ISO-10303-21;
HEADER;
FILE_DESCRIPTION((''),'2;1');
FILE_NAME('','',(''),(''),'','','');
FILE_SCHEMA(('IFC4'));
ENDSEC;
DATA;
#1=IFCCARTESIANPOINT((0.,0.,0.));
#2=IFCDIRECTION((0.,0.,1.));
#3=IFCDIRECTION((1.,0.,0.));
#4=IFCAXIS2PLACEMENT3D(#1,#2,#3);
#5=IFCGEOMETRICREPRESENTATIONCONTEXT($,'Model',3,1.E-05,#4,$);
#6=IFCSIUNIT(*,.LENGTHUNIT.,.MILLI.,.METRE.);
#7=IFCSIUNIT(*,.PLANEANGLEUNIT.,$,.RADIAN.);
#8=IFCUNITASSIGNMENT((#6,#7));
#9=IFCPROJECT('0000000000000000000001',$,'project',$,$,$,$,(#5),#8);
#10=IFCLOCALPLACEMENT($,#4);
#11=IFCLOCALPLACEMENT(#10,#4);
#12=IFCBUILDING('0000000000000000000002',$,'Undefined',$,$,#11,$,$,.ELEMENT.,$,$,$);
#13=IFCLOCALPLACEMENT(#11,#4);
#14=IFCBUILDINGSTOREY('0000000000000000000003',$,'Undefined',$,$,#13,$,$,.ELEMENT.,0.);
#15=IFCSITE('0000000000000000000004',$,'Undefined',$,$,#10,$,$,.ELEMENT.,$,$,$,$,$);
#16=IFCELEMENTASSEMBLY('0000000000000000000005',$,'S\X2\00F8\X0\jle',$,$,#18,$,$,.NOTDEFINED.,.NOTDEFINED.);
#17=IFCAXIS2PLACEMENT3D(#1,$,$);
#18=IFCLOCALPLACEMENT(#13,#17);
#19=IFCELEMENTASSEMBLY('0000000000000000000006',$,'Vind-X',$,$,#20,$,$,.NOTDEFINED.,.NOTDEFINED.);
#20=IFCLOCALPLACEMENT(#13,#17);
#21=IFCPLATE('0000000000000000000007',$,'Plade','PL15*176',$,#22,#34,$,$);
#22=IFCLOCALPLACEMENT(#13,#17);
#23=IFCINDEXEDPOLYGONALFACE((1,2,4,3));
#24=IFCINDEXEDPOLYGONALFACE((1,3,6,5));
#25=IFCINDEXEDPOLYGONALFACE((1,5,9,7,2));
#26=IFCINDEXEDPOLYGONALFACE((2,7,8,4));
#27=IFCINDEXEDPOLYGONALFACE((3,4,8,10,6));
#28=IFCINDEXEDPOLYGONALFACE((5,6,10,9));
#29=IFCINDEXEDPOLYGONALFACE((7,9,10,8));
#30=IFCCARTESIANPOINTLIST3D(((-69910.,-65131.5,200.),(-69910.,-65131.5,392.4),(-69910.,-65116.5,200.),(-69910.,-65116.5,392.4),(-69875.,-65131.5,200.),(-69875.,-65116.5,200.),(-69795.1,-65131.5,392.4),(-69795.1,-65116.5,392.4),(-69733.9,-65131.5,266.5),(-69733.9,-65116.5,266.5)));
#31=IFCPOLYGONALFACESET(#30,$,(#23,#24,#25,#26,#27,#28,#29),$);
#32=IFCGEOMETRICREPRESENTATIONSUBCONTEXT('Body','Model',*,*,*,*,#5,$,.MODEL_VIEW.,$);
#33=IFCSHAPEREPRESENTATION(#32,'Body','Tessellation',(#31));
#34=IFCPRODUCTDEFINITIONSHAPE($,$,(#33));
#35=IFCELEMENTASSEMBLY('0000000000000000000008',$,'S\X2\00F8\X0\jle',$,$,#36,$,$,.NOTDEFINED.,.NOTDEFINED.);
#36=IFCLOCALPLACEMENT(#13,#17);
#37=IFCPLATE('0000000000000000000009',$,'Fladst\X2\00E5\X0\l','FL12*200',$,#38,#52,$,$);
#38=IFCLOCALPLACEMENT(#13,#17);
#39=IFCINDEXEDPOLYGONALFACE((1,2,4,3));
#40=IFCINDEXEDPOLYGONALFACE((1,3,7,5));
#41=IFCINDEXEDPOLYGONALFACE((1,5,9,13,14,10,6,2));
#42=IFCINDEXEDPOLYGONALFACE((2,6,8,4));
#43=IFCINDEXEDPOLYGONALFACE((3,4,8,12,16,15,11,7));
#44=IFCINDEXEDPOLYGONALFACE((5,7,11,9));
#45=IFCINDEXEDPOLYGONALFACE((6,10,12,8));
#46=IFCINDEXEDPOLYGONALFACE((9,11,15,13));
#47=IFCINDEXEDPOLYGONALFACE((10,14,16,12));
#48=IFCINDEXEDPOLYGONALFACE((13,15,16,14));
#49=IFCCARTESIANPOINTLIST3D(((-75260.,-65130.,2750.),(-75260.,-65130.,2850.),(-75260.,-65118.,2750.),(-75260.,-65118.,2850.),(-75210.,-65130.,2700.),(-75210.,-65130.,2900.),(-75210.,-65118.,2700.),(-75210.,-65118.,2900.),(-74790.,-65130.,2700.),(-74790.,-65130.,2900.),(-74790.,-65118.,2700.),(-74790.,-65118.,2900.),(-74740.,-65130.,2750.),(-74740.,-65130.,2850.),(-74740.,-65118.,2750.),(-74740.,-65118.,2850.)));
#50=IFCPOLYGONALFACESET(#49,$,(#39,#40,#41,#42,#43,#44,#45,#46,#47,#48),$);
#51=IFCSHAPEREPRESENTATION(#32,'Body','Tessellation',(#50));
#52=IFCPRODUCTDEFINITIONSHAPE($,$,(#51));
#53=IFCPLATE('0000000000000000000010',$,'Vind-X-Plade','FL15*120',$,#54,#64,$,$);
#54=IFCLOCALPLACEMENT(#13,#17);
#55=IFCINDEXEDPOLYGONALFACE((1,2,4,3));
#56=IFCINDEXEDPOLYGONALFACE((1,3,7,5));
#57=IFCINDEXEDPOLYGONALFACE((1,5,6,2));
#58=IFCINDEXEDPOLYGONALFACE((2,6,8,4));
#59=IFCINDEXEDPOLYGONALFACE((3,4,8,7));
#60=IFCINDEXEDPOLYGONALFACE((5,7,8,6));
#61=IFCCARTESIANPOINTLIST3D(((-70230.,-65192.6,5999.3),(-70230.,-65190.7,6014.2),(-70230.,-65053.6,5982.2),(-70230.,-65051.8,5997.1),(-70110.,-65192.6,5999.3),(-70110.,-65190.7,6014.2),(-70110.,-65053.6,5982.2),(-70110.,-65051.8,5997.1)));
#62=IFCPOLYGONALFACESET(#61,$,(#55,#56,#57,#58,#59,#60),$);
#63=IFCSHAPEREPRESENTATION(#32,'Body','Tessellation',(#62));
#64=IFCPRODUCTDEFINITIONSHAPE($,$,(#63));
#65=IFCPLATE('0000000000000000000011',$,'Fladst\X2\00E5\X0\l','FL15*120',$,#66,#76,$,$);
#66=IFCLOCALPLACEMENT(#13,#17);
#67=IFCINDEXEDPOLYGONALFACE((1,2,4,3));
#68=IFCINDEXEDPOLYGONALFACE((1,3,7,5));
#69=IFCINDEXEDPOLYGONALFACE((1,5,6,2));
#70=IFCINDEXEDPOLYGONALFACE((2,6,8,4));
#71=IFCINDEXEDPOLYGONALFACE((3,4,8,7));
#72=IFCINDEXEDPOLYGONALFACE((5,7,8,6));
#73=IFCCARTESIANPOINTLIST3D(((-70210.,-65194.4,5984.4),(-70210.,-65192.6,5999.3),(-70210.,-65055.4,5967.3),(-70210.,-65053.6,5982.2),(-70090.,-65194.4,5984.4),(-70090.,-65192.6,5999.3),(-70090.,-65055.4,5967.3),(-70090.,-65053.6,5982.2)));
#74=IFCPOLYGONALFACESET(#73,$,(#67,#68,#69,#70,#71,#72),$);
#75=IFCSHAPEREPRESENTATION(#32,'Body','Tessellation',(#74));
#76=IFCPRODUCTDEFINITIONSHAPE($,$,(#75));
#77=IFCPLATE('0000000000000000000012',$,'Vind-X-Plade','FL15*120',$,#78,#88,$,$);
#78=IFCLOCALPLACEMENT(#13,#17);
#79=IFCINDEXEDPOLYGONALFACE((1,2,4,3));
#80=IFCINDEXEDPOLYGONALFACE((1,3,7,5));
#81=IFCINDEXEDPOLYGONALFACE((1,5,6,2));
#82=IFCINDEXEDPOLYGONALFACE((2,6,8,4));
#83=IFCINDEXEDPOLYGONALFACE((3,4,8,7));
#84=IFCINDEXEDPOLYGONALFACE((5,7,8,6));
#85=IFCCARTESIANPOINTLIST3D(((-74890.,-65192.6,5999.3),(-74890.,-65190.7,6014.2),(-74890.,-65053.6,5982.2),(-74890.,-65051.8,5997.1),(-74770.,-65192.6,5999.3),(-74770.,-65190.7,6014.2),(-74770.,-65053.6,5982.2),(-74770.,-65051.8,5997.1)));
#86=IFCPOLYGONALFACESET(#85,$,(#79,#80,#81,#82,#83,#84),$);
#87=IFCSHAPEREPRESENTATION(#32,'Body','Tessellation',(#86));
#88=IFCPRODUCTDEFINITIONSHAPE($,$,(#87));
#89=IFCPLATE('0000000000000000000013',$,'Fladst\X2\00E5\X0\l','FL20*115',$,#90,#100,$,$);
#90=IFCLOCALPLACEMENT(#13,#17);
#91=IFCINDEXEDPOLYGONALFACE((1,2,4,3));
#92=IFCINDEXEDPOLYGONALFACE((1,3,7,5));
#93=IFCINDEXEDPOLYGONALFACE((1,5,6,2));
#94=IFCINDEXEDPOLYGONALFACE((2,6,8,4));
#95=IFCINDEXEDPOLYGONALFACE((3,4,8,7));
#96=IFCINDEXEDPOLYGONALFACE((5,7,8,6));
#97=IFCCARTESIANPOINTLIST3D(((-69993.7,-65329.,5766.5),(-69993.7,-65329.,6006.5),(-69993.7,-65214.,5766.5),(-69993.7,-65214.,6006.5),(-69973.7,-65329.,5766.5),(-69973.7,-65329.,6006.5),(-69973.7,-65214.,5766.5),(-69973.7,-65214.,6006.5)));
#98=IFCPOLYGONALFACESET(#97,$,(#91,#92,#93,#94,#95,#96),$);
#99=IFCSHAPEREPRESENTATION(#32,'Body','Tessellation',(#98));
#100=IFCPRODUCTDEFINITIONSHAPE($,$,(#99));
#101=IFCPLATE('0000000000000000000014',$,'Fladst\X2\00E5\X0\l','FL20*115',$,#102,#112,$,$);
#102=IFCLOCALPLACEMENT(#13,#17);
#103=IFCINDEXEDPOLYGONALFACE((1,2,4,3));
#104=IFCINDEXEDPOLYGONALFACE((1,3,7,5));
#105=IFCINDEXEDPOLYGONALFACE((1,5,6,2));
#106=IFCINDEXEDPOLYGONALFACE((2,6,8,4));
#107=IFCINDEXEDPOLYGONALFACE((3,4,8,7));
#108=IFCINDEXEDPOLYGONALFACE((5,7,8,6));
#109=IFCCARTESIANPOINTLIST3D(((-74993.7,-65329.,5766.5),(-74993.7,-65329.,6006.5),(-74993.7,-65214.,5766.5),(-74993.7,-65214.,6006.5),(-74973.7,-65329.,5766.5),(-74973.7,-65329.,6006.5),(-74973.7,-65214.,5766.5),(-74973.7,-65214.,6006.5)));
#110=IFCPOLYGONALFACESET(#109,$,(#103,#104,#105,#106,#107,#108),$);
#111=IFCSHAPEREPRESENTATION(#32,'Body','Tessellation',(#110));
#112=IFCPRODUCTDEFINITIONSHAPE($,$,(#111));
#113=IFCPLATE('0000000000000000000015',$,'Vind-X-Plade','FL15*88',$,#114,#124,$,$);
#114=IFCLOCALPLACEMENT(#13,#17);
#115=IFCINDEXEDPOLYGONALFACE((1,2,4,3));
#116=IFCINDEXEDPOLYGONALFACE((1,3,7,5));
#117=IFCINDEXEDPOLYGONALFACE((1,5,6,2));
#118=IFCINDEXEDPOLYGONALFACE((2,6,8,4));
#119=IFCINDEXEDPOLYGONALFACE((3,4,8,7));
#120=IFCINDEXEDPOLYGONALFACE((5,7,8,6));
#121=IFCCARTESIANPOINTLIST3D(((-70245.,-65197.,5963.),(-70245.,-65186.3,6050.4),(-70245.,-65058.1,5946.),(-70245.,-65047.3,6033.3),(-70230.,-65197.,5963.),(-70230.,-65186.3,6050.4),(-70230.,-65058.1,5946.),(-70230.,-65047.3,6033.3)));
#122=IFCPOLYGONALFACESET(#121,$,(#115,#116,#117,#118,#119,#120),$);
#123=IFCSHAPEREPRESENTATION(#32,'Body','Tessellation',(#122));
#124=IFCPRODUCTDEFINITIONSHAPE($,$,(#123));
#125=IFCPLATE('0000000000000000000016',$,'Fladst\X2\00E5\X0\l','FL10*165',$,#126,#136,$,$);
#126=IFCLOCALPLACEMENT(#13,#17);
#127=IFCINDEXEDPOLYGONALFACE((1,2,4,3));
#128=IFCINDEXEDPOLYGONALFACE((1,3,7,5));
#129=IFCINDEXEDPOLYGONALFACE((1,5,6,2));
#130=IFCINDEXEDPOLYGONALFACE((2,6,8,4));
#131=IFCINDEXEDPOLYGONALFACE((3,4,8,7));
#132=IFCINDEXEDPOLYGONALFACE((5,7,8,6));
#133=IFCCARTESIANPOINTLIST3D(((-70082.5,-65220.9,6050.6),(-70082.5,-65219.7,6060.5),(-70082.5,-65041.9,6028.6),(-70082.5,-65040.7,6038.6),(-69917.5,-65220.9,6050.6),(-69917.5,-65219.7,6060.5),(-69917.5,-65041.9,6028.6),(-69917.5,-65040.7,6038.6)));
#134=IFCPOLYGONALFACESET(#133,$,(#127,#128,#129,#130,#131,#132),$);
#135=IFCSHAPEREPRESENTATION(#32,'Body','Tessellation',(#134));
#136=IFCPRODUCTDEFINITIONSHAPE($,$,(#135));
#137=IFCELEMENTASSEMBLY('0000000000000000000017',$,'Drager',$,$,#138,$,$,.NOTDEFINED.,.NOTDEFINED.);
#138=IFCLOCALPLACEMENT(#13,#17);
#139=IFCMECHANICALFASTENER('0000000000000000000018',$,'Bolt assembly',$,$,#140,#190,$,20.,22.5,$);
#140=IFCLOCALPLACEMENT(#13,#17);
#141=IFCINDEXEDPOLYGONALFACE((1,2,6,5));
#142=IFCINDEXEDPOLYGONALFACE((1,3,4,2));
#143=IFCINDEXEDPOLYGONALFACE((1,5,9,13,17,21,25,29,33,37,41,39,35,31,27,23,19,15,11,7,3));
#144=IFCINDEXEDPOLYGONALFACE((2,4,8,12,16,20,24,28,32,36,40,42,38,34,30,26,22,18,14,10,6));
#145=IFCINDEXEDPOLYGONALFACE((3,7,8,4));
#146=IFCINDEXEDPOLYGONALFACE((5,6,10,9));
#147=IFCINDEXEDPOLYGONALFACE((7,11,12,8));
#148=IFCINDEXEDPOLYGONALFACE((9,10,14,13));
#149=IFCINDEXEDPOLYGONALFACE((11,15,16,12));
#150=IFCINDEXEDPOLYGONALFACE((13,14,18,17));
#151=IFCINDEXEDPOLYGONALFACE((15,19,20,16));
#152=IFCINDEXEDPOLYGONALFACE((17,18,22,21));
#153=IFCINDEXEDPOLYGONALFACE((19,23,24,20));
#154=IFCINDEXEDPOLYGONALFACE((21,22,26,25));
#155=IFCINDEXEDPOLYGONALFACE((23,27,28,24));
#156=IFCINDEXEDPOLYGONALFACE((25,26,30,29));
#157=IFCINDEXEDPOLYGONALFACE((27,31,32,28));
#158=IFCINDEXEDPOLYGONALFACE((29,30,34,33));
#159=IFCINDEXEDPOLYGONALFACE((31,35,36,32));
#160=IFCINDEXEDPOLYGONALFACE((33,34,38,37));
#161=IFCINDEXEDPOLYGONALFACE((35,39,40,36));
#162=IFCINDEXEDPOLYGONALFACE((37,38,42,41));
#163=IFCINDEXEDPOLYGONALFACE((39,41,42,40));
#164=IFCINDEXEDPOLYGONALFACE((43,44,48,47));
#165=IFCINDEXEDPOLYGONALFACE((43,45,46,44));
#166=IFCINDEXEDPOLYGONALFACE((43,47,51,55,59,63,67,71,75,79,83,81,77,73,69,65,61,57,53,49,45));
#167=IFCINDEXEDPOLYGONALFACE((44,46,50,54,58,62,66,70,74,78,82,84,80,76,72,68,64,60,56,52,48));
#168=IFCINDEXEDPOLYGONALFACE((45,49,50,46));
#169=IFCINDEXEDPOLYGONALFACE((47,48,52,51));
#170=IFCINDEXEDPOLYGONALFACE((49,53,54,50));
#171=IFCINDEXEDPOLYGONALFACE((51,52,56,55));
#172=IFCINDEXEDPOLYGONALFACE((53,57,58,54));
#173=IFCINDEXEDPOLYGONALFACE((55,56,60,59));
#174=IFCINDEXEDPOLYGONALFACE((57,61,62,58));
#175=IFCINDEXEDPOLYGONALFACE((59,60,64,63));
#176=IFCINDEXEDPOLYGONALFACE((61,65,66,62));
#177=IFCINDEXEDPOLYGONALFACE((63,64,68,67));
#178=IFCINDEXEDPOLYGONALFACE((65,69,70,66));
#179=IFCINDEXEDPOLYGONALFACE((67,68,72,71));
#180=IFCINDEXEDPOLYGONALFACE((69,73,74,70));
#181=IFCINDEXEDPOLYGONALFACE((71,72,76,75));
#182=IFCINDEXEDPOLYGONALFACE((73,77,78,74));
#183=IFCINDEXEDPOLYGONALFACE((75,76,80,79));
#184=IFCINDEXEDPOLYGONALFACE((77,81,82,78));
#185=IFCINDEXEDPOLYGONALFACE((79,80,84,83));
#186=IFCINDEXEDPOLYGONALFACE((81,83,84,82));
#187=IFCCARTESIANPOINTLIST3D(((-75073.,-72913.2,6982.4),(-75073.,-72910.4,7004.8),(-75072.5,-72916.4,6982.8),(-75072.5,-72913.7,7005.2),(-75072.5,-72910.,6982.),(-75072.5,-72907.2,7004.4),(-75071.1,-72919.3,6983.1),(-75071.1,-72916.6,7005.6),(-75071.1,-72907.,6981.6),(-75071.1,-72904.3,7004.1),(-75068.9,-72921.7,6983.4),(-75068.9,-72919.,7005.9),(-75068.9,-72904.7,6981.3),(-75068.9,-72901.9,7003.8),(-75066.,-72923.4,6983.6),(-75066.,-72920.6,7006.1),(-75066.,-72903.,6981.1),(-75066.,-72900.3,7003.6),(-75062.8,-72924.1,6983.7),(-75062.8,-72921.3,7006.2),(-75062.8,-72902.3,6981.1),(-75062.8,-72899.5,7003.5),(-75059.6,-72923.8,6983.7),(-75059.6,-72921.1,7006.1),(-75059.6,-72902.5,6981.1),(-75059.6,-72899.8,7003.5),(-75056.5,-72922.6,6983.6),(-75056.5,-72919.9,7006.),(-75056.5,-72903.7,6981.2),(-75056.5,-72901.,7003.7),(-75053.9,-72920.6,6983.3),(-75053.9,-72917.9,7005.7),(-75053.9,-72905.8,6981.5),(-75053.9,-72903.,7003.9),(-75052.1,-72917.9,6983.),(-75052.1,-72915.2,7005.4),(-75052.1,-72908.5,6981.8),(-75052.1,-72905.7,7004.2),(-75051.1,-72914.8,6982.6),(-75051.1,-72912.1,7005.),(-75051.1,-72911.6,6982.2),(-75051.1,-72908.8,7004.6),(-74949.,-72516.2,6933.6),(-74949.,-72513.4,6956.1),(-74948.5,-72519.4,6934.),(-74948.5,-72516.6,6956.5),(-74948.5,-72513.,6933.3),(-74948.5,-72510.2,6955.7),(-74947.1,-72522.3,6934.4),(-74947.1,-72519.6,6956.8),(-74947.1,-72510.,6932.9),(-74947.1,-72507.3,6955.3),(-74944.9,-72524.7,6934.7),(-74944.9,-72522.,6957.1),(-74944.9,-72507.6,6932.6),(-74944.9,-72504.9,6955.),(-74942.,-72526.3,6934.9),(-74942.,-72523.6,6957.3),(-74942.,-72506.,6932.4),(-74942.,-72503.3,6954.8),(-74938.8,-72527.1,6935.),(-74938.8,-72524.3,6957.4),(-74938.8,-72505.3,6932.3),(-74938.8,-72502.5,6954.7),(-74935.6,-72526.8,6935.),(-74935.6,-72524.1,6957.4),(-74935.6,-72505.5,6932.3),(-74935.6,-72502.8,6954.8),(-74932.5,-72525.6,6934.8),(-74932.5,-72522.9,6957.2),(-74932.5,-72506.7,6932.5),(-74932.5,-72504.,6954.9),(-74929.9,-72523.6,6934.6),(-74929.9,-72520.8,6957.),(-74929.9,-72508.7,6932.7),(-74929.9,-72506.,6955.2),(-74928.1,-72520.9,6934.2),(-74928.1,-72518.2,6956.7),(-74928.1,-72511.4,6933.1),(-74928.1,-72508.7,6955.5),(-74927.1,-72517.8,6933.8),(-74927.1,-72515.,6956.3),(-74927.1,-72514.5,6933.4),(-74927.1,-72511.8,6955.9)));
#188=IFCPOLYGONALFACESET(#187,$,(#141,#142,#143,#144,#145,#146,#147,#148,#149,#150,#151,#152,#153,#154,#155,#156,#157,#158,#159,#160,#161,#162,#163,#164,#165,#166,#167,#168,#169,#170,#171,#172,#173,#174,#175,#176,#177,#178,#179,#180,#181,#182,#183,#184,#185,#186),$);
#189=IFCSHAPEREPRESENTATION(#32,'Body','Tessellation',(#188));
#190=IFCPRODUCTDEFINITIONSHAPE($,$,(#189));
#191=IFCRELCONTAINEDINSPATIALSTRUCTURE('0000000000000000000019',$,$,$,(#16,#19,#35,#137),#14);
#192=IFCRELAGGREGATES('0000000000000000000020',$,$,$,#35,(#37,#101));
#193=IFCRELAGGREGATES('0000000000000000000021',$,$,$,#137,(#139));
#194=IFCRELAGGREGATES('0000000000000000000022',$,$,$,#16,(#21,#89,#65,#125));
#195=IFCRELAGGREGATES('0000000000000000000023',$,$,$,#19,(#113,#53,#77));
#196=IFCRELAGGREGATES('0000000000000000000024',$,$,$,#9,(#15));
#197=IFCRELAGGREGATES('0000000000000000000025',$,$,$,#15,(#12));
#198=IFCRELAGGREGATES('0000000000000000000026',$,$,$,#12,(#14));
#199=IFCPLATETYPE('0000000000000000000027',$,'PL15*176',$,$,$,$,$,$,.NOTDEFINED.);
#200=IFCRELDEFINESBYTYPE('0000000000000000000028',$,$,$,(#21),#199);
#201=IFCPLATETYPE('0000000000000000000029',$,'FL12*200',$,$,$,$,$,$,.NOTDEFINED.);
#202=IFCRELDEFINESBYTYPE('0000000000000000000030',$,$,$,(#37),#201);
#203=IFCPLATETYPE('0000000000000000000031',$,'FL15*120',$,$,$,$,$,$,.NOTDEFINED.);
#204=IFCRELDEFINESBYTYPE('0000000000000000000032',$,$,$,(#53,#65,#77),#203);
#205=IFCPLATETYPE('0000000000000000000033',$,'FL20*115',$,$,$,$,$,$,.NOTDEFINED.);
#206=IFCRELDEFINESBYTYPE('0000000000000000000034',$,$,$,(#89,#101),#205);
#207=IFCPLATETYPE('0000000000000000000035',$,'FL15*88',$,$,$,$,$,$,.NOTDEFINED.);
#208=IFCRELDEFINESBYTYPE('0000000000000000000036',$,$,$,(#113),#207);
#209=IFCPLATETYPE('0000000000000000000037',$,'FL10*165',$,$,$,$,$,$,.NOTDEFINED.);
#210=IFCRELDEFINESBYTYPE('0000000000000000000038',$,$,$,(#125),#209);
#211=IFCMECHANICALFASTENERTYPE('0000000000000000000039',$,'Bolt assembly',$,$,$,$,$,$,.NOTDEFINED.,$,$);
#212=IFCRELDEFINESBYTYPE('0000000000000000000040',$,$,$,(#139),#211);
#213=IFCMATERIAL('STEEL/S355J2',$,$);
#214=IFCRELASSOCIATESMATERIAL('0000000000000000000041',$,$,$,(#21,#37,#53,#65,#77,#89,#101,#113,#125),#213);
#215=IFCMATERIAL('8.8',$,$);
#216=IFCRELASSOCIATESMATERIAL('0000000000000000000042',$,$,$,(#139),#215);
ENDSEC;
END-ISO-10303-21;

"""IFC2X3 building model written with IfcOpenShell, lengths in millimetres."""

from ifc_helpers import new_model, si_unit, frame, origin_with_axes, origin_2d_with_axis, place, context, subcontext, project, spatial, polyline, circle, outline, extrude, source, transform, mapped, material, type_object, element, aggregate, save


model = new_model("IFC2X3")

# Units and contexts
model_context = context("Model", 3, precision=1e-05, world=origin_with_axes())
body_context = subcontext(model_context, "Body", "Model", "MODEL_VIEW")
ifc_project = project(units=[si_unit("LENGTHUNIT", "METRE", prefix="MILLI"), si_unit("PLANEANGLEUNIT", "RADIAN")], contexts=[model_context])

# Site, building, storey
site_placement = place(None, origin_with_axes())
site = spatial("IfcSite", under=ifc_project, at=site_placement, Name="Undefined", CompositionType="ELEMENT")
building_placement = place(site_placement, origin_with_axes())
building = spatial("IfcBuilding", under=site, at=building_placement, Name="Undefined", CompositionType="ELEMENT")
storey_placement = place(building_placement, origin_with_axes())
storey = spatial("IfcBuildingStorey", under=building, at=storey_placement, Name="Undefined", CompositionType="ELEMENT", Elevation=0.0)

# Element assembly
assembly_1_placement = place(storey_placement, origin_with_axes())
assembly_1 = element("IfcElementAssembly", 1, at=assembly_1_placement, inside=storey, Name="Søjle", AssemblyPlace="NOTDEFINED", PredefinedType="NOTDEFINED")

# Element assembly
assembly_2_placement = place(storey_placement, origin_with_axes())
assembly_2 = element("IfcElementAssembly", 2, at=assembly_2_placement, inside=storey, Name="Vind-X", AssemblyPlace="NOTDEFINED", PredefinedType="NOTDEFINED")

# Shared definitions
ifc_material_1 = material(Name="STEEL/S355J2")

# Plate
plate_type_1 = type_object("IfcPlateType", Name="PL15*176", PredefinedType="NOTDEFINED")
plate_1_placement = place(assembly_1_placement, frame((-69910.0, -65124.0, 200.0), z_axis=(0.0, 1.0, 0.0), x_axis=(0.0, 0.0, 1.0)))
plate_1 = element("IfcPlate", 3, at=plate_1_placement, type_object=plate_type_1, material=ifc_material_1, Name="Plade", Description="PL15*176", context=body_context, shape_type="SweptSolid", body=[
    extrude(outline(polyline([(0.0, 0.0), (192.4, 0.0), (192.4, 114.9), (66.5, 176.1), (0.0, 35.0), (0.0, 0.0)])), frame((0.0, 0.0, -7.5), z_axis=(0.0, 0.0, 1.0), x_axis=(1.0, 0.0, 0.0)), (0.0, 0.0, 1.0), 15.0),
])

# Element assembly, plate
assembly_3_placement = place(storey_placement, origin_with_axes())
assembly_3 = element("IfcElementAssembly", 4, at=assembly_3_placement, inside=storey, Name="Søjle", AssemblyPlace="NOTDEFINED", PredefinedType="NOTDEFINED")
plate_type_2 = type_object("IfcPlateType", Name="FL12*200", PredefinedType="NOTDEFINED")
plate_2_placement = place(assembly_3_placement, frame((-74740.0, -65124.0, 2900.0), z_axis=(0.0, 1.0, 0.0), x_axis=(0.0, 0.0, -1.0)))
plate_2 = element("IfcPlate", 5, at=plate_2_placement, type_object=plate_type_2, material=ifc_material_1, Name="Fladstål", Description="FL12*200", context=body_context, shape_type="SweptSolid", body=[
    extrude(outline(polyline([(0.0, 50.0), (50.0, 0.0), (150.0, 0.0), (200.0, 50.0), (200.0, 470.0), (150.0, 520.0), (50.0, 520.0), (0.0, 470.0), (0.0, 50.0)])), frame((0.0, 0.0, -6.0), z_axis=(0.0, 0.0, 1.0), x_axis=(1.0, 0.0, 0.0)), (0.0, 0.0, 1.0), 12.0),
])

# Plates
plate_type_3 = type_object("IfcPlateType", Name="FL15*120", PredefinedType="NOTDEFINED")
plate_3_placement = place(assembly_2_placement, frame((-70110.0, -65122.2, 5998.2), z_axis=(0.0, -0.121869, -0.992546), x_axis=(-1.0, 0.0, 0.0)))
plate_3 = element("IfcPlate", 6, at=plate_3_placement, type_object=plate_type_3, material=ifc_material_1, Name="Vind-X-Plade", Description="FL15*120", context=body_context, shape_type="SweptSolid", body=[
    extrude(outline(polyline([(0.0, -70.0), (0.0, 70.0), (120.0, 70.0), (120.0, -70.0), (0.0, -70.0)])), frame((0.0, 0.0, -7.5), z_axis=(0.0, 0.0, 1.0), x_axis=(1.0, 0.0, 0.0)), (0.0, 0.0, 1.0), 15.0),
])
plate_4_placement = place(assembly_1_placement, frame((-70090.0, -65193.5, 5991.8), z_axis=(0.0, 0.121869, 0.992546), x_axis=(0.0, 0.992546, -0.121869)))
plate_4 = element("IfcPlate", 7, at=plate_4_placement, type_object=plate_type_3, material=ifc_material_1, Name="Fladstål", Description="FL15*120", context=body_context, shape_type="SweptSolid", body=[
    extrude(outline(polyline([(0.0, 0.0), (140.0, 0.0), (140.0, 120.0), (0.0, 120.0), (0.0, 0.0)])), frame((0.0, 0.0, -7.5), z_axis=(0.0, 0.0, 1.0), x_axis=(1.0, 0.0, 0.0)), (0.0, 0.0, 1.0), 15.0),
])
plate_5_placement = place(assembly_2_placement, frame((-74890.0, -65122.2, 5998.2), z_axis=(0.0, -0.121869, -0.992546), x_axis=(1.0, 0.0, 0.0)))
plate_5 = element("IfcPlate", 8, at=plate_5_placement, type_object=plate_type_3, material=ifc_material_1, Name="Vind-X-Plade", Description="FL15*120", context=body_context, shape_type="SweptSolid", body=[
    extrude(outline(polyline([(0.0, -70.0), (0.0, 70.0), (120.0, 70.0), (120.0, -70.0), (0.0, -70.0)])), frame((0.0, 0.0, -7.5), z_axis=(0.0, 0.0, 1.0), x_axis=(1.0, 0.0, 0.0)), (0.0, 0.0, 1.0), 15.0),
])
plate_type_4 = type_object("IfcPlateType", Name="FL20*115", PredefinedType="NOTDEFINED")
plate_6_placement = place(assembly_1_placement, frame((-69983.7, -65214.0, 6006.5), z_axis=(-1.0, 0.0, 0.0), x_axis=(0.0, 0.0, -1.0)))
plate_6 = element("IfcPlate", 9, at=plate_6_placement, type_object=plate_type_4, material=ifc_material_1, Name="Fladstål", Description="FL20*115", context=body_context, shape_type="SweptSolid", body=[
    extrude(outline(polyline([(0.0, 0.0), (240.0, 0.0), (240.0, 115.0), (0.0, 115.0), (0.0, 0.0)])), frame((0.0, 0.0, -10.0), z_axis=(0.0, 0.0, 1.0), x_axis=(1.0, 0.0, 0.0)), (0.0, 0.0, 1.0), 20.0),
])
plate_7_placement = place(assembly_3_placement, frame((-74983.7, -65214.0, 6006.5), z_axis=(-1.0, 0.0, 0.0), x_axis=(0.0, 0.0, -1.0)))
plate_7 = element("IfcPlate", 10, at=plate_7_placement, type_object=plate_type_4, material=ifc_material_1, Name="Fladstål", Description="FL20*115", context=body_context, shape_type="SweptSolid", body=[
    extrude(outline(polyline([(0.0, 0.0), (240.0, 0.0), (240.0, 115.0), (0.0, 115.0), (0.0, 0.0)])), frame((0.0, 0.0, -10.0), z_axis=(0.0, 0.0, 1.0), x_axis=(1.0, 0.0, 0.0)), (0.0, 0.0, 1.0), 20.0),
])
aggregate(assembly_3, [plate_2, plate_7])
plate_type_5 = type_object("IfcPlateType", Name="FL15*88", PredefinedType="NOTDEFINED")
plate_8_placement = place(assembly_2_placement, frame((-70237.5, -65197.0, 5963.0), z_axis=(1.0, 0.0, 0.0), x_axis=(0.0, 0.992546, -0.121869)))
plate_8 = element("IfcPlate", 11, at=plate_8_placement, type_object=plate_type_5, material=ifc_material_1, Name="Vind-X-Plade", Description="FL15*88", context=body_context, shape_type="SweptSolid", body=[
    extrude(outline(polyline([(0.0, 0.0), (140.0, 0.0), (140.0, 88.0), (0.0, 88.0), (0.0, 0.0)])), frame((0.0, 0.0, -7.5), z_axis=(0.0, 0.0, 1.0), x_axis=(1.0, 0.0, 0.0)), (0.0, 0.0, 1.0), 15.0),
])
plate_type_6 = type_object("IfcPlateType", Name="FL10*165", PredefinedType="NOTDEFINED")
plate_9_placement = place(assembly_1_placement, frame((-70000.0, -65220.3, 6055.6), z_axis=(0.0, -0.121869, -0.992546), x_axis=(0.0, 0.992546, -0.121869)))
plate_9 = element("IfcPlate", 12, at=plate_9_placement, type_object=plate_type_6, material=ifc_material_1, Name="Fladstål", Description="FL10*165", context=body_context, shape_type="SweptSolid", body=[
    extrude(outline(polyline([(0.0, -82.5), (0.0, 82.5), (180.4, 82.5), (180.4, -82.5), (0.0, -82.5)])), frame((0.0, 0.0, -5.0), z_axis=(0.0, 0.0, 1.0), x_axis=(1.0, 0.0, 0.0)), (0.0, 0.0, 1.0), 10.0),
])

# Element assembly, mechanical fastener
assembly_4_placement = place(storey_placement, origin_with_axes())
assembly_4 = element("IfcElementAssembly", 13, at=assembly_4_placement, inside=storey, Name="Drager", AssemblyPlace="NOTDEFINED", PredefinedType="NOTDEFINED")
ifc_material_2 = material(Name="8.8")
mechanical_fastener_type = type_object("IfcMechanicalFastenerType", Name="Bolt assembly")
shared_shape_1 = source(origin_with_axes(), body_context, "Body", "SweptSolid", [
    extrude(circle(Radius=11.0, at=origin_2d_with_axis()), frame((0.0, 0.0, 0.0), z_axis=(0.0, 1.0, 0.0), x_axis=(1.0, 0.0, 0.0)), (0.0, 0.0, 1.0), 22.6),
])
mechanical_fastener_1_placement = place(assembly_4_placement, frame((-74850.0, -72711.9, 6980.5), z_axis=(0.0, -0.992546, 0.121869), x_axis=(-1.0, 0.0, 0.0)))
mechanical_fastener_1 = element("IfcMechanicalFastener", 14, at=mechanical_fastener_1_placement, type_object=mechanical_fastener_type, material=ifc_material_2, Name="Bolt assembly", NominalDiameter=20.0, NominalLength=22.5, context=body_context, shape_type="MappedRepresentation", body=[
    mapped(shared_shape_1, transform((88.0, 0.0, -200.0))),
    mapped(shared_shape_1, transform((212.0, 0.0, 200.0))),
])
aggregate(assembly_4, [mechanical_fastener_1])

aggregate(assembly_1, [plate_1, plate_6, plate_4, plate_9])
aggregate(assembly_2, [plate_8, plate_3, plate_5])

save(model, "model.ifc")
